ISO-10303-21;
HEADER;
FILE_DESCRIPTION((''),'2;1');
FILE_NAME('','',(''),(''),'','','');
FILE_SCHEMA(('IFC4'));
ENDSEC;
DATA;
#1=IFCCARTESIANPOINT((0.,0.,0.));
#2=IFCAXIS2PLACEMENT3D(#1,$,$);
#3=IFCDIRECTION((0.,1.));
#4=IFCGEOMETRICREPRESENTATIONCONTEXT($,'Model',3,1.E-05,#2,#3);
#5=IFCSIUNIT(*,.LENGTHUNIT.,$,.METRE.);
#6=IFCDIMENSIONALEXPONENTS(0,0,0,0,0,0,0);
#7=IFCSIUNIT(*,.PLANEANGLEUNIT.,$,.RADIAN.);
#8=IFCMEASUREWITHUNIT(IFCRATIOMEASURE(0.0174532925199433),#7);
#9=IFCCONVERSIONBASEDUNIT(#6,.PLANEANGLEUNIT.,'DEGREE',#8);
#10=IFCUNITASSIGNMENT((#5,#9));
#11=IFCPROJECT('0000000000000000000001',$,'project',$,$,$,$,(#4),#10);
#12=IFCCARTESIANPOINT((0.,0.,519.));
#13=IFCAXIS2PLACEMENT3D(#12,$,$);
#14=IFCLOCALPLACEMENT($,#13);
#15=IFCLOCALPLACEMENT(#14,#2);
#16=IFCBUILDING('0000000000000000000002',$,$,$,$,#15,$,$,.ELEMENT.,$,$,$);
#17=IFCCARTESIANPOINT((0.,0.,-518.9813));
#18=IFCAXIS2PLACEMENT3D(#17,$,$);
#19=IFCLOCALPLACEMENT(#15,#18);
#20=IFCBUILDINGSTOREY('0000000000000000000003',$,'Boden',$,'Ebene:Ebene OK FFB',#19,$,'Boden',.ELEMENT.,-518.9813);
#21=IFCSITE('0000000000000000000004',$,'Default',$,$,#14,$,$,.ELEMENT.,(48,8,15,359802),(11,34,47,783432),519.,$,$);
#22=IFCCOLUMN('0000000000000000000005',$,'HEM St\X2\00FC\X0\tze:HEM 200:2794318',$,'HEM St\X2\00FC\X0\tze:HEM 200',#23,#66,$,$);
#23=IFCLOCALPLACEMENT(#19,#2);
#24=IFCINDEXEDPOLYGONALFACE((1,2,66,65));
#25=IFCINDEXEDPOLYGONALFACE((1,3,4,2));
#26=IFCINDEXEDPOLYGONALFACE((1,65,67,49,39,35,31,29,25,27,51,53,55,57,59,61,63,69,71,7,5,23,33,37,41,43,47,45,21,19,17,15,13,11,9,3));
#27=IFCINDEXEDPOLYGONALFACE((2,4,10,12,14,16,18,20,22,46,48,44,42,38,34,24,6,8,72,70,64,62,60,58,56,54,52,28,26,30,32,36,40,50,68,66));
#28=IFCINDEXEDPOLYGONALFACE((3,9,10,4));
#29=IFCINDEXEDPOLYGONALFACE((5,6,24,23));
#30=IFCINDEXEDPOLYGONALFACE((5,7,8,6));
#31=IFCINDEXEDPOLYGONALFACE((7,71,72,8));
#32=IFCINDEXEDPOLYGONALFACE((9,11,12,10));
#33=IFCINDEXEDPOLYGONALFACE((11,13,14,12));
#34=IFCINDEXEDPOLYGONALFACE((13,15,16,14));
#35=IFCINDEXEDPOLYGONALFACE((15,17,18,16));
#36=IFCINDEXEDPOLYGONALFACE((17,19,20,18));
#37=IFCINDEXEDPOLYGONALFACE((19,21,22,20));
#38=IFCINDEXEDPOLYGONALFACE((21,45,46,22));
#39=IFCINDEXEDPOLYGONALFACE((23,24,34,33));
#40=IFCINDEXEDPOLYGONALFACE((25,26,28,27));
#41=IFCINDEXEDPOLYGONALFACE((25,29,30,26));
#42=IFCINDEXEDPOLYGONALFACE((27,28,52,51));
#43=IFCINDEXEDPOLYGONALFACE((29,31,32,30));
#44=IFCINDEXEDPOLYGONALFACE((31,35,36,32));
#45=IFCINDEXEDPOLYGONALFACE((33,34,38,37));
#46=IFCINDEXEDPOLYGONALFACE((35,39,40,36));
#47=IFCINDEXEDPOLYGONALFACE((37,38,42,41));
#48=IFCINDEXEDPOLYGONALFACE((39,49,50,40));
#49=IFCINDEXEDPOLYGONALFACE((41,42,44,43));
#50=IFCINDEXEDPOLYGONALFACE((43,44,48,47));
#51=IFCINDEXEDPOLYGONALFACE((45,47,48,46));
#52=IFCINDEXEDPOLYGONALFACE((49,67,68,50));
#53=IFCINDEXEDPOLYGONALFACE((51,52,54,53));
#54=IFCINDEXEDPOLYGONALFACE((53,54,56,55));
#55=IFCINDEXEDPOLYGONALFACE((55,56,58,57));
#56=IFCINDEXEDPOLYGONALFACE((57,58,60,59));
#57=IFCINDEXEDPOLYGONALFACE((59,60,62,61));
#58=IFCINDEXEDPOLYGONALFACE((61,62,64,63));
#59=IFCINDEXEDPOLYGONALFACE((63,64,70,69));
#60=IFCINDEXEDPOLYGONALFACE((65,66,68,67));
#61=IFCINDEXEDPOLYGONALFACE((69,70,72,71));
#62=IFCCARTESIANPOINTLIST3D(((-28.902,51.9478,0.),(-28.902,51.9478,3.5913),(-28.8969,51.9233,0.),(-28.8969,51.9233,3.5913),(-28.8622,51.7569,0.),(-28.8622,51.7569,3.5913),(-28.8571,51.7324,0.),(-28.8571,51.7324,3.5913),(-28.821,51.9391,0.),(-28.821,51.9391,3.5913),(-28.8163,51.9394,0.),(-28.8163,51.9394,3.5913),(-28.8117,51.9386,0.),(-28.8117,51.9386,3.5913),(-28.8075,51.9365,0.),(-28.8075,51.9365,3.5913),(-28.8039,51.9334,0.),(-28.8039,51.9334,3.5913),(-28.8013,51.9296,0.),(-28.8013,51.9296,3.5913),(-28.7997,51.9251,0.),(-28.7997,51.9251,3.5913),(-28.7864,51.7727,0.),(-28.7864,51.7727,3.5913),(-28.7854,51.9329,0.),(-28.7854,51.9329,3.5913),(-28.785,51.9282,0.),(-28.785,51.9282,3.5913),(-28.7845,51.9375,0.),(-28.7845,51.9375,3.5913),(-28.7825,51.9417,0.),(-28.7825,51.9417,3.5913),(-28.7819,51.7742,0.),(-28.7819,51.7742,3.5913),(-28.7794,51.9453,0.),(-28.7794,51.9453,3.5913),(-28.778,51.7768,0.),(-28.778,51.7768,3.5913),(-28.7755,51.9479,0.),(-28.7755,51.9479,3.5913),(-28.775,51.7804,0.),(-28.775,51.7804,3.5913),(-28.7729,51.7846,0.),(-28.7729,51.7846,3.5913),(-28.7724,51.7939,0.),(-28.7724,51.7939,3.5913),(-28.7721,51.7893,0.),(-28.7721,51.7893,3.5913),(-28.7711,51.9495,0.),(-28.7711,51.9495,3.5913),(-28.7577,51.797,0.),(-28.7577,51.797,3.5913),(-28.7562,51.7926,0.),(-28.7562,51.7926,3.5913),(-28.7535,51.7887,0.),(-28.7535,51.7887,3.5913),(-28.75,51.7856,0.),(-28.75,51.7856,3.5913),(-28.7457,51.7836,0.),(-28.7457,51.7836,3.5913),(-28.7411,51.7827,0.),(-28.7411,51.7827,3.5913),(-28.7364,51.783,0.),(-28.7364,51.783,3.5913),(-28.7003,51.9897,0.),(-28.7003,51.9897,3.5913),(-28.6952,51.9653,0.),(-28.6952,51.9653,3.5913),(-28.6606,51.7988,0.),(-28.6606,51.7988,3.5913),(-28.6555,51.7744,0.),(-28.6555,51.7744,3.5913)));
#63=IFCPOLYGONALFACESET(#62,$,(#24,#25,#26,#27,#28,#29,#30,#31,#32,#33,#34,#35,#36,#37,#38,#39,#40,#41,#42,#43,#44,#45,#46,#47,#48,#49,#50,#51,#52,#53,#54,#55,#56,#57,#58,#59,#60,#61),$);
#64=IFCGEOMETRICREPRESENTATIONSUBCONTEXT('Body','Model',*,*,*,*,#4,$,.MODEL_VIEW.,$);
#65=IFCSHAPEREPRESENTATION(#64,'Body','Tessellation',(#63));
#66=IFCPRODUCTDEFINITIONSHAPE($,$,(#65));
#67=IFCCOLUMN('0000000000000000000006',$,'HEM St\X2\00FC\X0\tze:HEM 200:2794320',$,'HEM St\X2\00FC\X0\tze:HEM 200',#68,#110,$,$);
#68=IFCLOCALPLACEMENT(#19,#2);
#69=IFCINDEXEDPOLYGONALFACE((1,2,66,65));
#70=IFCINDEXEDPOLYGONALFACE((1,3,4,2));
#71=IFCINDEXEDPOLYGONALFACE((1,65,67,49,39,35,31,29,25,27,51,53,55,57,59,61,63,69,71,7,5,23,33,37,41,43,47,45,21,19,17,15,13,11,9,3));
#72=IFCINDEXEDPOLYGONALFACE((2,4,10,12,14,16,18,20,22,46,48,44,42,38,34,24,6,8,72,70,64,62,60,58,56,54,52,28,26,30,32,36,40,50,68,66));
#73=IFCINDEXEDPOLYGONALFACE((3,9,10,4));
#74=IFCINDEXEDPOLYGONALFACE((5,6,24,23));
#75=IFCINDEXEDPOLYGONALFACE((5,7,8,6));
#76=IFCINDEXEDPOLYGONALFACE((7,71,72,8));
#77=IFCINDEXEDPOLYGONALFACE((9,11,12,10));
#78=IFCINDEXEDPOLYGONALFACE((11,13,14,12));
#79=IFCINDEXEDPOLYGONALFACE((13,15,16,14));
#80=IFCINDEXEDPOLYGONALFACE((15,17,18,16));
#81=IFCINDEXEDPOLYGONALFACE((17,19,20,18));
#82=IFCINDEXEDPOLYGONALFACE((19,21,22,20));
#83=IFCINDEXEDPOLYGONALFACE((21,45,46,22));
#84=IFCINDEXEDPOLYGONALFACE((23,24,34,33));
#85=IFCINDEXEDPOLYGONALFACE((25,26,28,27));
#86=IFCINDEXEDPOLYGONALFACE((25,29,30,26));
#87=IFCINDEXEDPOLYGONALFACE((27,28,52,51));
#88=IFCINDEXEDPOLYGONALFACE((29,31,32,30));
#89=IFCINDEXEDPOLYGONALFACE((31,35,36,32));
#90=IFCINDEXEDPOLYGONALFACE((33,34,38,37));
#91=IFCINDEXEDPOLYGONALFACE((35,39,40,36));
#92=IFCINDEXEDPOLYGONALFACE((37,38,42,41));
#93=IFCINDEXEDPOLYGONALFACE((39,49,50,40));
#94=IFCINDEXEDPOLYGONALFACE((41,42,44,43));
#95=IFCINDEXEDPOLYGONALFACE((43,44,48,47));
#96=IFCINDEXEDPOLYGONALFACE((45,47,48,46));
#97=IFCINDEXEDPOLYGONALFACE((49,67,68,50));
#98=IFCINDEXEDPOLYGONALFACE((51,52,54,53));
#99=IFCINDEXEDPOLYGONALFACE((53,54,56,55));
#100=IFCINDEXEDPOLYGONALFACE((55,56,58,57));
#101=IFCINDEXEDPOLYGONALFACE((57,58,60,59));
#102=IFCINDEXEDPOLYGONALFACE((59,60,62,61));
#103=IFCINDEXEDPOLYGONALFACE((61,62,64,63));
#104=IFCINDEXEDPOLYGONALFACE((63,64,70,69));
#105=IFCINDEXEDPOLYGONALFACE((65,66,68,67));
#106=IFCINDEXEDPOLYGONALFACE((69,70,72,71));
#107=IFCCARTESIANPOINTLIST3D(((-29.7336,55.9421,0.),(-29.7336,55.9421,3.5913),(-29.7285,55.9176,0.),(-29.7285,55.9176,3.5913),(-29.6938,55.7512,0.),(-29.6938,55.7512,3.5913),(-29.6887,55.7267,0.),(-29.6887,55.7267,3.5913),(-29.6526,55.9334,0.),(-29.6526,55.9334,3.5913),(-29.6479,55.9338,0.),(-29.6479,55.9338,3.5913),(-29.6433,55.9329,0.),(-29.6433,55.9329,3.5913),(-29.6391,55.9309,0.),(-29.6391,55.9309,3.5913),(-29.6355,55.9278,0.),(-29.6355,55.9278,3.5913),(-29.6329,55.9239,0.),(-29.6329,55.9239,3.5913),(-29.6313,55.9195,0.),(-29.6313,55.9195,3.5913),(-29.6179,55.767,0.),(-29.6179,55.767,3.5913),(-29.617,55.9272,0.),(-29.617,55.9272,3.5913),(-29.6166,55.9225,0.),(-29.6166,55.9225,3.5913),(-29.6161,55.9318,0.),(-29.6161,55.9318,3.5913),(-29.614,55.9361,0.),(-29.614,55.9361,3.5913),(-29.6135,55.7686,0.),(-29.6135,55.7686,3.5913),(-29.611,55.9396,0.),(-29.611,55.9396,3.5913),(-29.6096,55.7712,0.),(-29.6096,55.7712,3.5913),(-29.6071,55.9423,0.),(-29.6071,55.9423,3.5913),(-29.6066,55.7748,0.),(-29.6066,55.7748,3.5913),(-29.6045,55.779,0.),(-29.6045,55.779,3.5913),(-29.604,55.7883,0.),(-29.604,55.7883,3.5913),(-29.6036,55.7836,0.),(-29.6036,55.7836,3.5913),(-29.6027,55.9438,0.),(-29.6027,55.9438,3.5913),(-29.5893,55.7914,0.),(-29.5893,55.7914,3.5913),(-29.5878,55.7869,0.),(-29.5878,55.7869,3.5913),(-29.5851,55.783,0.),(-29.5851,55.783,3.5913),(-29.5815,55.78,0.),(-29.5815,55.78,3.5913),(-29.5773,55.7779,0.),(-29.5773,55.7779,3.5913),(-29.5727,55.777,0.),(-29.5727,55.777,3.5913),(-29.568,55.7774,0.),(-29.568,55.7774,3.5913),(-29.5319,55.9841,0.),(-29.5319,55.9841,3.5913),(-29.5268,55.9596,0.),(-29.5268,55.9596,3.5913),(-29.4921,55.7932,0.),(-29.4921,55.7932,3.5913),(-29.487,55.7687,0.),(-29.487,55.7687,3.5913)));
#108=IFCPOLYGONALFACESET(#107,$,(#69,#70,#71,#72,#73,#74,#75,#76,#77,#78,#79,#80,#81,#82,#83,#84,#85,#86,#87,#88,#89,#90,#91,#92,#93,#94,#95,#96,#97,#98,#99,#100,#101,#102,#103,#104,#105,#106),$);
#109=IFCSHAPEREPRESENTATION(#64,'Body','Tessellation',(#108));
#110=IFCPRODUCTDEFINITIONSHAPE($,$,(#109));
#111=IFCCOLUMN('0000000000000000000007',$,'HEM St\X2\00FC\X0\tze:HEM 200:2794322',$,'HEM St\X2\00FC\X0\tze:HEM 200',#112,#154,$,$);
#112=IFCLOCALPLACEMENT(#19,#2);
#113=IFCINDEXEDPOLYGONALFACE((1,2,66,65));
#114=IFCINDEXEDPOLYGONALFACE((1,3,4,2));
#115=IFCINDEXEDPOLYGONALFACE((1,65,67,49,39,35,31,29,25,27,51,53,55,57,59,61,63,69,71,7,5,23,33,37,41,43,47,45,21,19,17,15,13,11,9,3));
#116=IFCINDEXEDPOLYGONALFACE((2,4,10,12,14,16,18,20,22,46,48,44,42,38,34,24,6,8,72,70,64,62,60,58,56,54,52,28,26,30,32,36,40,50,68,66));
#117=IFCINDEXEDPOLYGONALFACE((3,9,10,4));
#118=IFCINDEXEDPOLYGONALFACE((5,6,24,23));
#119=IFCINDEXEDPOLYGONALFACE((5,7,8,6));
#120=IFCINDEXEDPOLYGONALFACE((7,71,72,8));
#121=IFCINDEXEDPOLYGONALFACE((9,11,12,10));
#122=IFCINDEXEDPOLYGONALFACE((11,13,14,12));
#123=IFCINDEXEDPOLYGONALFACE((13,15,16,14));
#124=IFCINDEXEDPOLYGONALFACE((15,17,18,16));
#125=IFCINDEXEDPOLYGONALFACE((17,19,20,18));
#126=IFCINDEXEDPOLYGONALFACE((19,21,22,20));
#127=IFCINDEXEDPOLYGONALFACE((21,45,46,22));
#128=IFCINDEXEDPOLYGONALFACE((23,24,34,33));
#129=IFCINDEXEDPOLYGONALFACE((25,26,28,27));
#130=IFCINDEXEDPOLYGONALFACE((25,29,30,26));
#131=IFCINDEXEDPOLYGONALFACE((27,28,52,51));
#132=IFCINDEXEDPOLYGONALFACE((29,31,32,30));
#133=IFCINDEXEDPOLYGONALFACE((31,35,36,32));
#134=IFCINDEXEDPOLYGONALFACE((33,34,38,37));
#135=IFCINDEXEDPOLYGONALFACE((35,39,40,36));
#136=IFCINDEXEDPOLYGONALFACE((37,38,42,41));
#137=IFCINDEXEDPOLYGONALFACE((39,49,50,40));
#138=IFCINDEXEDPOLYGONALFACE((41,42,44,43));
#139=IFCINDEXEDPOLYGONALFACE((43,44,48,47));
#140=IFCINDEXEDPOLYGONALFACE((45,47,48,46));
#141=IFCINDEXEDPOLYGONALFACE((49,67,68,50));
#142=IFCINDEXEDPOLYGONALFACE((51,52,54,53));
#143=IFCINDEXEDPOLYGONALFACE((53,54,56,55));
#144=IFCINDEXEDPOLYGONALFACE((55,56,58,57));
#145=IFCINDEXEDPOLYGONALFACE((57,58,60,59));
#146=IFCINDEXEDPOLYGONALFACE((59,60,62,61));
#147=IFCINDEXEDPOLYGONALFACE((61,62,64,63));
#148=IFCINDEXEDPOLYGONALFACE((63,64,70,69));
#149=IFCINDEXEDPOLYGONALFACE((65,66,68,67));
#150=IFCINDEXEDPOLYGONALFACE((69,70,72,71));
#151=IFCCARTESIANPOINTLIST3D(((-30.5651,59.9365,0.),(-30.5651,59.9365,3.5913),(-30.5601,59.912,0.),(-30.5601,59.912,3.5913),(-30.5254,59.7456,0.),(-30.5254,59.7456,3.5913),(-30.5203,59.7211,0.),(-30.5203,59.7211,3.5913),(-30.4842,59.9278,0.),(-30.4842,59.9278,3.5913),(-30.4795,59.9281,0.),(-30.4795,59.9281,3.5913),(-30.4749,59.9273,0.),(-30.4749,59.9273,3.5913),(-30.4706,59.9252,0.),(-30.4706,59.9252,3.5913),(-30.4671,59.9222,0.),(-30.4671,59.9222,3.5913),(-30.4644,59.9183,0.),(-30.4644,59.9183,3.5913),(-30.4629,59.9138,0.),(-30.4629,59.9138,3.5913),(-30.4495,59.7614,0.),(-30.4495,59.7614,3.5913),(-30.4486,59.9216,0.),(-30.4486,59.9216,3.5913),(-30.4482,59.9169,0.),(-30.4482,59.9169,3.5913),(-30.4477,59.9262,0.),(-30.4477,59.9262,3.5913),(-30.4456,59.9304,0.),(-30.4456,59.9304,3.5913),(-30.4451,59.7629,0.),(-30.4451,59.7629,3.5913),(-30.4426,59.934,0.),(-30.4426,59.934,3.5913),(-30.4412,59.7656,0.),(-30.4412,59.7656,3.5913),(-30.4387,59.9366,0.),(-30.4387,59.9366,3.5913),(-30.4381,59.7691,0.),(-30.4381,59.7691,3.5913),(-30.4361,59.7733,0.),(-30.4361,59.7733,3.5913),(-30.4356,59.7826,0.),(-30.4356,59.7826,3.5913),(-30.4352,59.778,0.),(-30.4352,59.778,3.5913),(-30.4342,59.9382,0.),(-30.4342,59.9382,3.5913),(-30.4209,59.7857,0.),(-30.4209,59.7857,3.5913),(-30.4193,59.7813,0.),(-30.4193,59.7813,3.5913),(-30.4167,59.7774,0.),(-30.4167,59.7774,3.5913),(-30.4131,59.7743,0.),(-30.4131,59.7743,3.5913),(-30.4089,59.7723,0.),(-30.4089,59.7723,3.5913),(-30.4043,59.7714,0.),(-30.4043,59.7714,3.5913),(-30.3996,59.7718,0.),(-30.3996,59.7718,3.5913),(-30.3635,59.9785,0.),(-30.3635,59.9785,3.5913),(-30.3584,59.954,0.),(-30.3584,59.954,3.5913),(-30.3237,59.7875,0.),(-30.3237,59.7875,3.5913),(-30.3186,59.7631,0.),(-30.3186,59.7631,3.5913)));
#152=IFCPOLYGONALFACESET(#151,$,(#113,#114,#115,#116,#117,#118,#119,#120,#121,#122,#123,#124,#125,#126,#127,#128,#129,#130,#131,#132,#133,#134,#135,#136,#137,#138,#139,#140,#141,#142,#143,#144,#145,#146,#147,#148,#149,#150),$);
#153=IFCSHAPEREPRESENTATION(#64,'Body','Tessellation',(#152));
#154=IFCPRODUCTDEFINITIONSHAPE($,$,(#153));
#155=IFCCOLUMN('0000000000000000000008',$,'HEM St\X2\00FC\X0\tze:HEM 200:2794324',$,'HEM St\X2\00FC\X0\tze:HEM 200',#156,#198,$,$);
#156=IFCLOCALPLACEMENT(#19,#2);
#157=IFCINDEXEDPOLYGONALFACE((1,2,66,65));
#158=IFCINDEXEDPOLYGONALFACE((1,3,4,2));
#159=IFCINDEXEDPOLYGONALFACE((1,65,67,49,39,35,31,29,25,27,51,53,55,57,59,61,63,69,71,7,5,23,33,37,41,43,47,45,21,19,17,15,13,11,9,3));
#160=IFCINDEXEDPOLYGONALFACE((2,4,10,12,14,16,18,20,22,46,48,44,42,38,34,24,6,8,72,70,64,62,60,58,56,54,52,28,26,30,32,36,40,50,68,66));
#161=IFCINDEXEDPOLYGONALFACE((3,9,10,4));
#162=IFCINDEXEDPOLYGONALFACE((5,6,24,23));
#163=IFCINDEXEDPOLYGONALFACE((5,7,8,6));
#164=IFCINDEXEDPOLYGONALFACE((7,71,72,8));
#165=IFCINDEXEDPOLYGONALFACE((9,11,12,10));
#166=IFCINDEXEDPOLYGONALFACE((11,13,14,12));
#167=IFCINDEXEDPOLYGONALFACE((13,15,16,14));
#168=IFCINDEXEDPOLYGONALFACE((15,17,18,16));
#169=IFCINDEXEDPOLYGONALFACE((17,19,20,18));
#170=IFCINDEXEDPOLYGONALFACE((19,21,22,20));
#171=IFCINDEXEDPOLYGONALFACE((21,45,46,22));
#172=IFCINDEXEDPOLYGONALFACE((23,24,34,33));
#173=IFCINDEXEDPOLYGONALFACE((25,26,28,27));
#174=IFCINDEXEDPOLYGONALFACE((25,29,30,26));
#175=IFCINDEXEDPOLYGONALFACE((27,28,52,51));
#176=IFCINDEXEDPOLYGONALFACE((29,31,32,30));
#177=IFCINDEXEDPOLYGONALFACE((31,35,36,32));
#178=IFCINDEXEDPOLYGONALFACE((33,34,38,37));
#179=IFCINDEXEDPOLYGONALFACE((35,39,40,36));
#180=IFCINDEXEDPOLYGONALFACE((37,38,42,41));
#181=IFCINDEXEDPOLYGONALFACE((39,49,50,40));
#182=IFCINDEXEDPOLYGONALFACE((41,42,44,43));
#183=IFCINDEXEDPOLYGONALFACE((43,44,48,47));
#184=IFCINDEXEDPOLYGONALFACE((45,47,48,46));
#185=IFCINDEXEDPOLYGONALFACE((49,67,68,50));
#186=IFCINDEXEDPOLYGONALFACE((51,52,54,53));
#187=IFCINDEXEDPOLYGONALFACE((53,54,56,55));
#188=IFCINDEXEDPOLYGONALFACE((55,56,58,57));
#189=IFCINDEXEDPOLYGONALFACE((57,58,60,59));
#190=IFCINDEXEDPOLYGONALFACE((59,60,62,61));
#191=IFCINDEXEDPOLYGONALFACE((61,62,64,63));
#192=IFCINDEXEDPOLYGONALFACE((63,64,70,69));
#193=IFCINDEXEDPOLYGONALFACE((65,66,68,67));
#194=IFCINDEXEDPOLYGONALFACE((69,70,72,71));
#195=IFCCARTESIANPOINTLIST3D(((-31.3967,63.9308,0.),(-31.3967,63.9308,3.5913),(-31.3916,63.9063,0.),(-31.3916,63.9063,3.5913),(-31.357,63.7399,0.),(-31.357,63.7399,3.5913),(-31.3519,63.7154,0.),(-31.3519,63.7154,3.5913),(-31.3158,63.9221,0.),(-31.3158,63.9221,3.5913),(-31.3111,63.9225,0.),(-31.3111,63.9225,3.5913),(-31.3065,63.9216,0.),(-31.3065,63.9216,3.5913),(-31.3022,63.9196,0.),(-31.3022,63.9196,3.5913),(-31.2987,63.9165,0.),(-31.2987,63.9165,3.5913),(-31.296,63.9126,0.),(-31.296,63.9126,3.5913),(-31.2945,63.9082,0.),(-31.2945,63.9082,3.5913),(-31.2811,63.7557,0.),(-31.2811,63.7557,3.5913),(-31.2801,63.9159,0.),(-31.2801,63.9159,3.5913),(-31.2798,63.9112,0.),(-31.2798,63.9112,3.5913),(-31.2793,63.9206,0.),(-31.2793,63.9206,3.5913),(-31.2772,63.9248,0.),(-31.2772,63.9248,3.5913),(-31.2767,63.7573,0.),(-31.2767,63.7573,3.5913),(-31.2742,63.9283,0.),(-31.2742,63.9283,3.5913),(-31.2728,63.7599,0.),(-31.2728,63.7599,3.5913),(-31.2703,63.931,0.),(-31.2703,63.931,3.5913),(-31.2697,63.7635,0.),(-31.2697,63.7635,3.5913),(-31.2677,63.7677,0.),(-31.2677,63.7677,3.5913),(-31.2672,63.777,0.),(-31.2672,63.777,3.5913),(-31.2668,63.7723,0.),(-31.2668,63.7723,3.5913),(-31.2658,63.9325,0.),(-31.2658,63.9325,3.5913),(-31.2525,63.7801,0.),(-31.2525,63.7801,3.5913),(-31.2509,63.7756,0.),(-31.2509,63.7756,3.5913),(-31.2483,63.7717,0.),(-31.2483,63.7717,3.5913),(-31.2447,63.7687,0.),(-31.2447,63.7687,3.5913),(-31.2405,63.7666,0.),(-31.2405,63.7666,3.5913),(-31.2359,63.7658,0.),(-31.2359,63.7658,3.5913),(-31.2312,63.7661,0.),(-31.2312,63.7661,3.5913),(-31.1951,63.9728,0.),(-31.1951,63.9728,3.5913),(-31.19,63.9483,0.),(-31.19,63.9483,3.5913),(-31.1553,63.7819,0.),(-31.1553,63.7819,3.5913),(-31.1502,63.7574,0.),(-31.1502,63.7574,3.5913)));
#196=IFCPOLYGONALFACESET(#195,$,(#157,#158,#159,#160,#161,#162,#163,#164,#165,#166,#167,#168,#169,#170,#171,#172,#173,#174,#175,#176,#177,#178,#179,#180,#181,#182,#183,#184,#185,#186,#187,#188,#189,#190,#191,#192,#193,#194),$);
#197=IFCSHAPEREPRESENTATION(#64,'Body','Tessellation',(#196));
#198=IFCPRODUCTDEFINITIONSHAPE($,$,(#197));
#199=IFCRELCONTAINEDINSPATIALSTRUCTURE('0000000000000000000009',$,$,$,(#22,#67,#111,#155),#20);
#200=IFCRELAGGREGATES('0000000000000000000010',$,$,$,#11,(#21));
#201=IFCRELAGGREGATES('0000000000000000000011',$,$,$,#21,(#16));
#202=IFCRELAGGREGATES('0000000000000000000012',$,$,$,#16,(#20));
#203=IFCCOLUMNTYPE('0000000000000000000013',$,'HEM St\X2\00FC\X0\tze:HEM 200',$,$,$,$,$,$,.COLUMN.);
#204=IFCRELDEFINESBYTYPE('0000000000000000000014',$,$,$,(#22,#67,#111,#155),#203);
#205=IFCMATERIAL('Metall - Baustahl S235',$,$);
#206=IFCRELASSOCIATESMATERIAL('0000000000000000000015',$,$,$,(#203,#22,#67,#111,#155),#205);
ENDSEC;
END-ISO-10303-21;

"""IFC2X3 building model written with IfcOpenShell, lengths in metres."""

from ifc_helpers import new_model, entity, si_unit, converted_unit, direction, frame, frame_2d, origin, place, context, subcontext, project, spatial, polyline, circle_curve, parameter, trimmed, segment, composite_curve, outline, extrude, source, transform, mapped, material, type_object, type_shapes, element, save


model = new_model("IFC2X3")

# Units and contexts
model_context = context("Model", 3, precision=1e-05, world=origin(), true_north=direction((0.0, 1.0)))
body_context = subcontext(model_context, "Body", "Model", "MODEL_VIEW")
ifc_project = project(units=[si_unit("LENGTHUNIT", "METRE"), converted_unit("PLANEANGLEUNIT", "DEGREE", entity("IfcRatioMeasure", 0.0174532925199433), si_unit("PLANEANGLEUNIT", "RADIAN"), dimensions=[0, 0, 0, 0, 0, 0, 0])], contexts=[model_context])

# Site, building, storey
site_placement = place(None, frame((0.0, 0.0, 519.0)))
site = spatial("IfcSite", under=ifc_project, at=site_placement, Name="Default", CompositionType="ELEMENT", RefLatitude=(48, 8, 15, 359802), RefLongitude=(11, 34, 47, 783432), RefElevation=519.0)
building_placement = place(site_placement, origin())
building = spatial("IfcBuilding", under=site, at=building_placement, CompositionType="ELEMENT")
storey_placement = place(building_placement, frame((0.0, 0.0, -518.9813)))
storey = spatial("IfcBuildingStorey", under=building, at=storey_placement, Name="Boden", ObjectType="Ebene:Ebene OK FFB", LongName="Boden", CompositionType="ELEMENT", Elevation=-518.9813)

# Columns
ifc_material = material(Name="Metall - Baustahl S235")
column_type = type_object("IfcColumnType", Name="HEM Stütze:HEM 200", PredefinedType="COLUMN", material=ifc_material)
shared_shape = source(origin(), body_context, "Body", "SweptSolid", [
    extrude(outline(composite_curve([segment(polyline([(0.085, -0.103), (0.11, -0.103)]), True, "CONTINUOUS"), segment(polyline([(0.11, -0.103), (0.11, 0.103)]), True, "CONTINUOUS"), segment(polyline([(0.11, 0.103), (0.085, 0.103)]), True, "CONTINUOUS"), segment(polyline([(0.085, 0.103), (0.085, 0.0255)]), True, "CONTINUOUS"), segment(trimmed(circle_curve(frame_2d((0.067, 0.0255), x_axis=(1.0, 0.0)), 0.018), [parameter(270.0)], [parameter(0.0)], True, "PARAMETER"), False, "CONTINUOUS"), segment(polyline([(0.067, 0.0075), (-0.067, 0.0075)]), True, "CONTINUOUS"), segment(trimmed(circle_curve(frame_2d((-0.067, 0.0255), x_axis=(0.0, -1.0)), 0.018), [parameter(270.0)], [parameter(0.0)], True, "PARAMETER"), False, "CONTINUOUS"), segment(polyline([(-0.085, 0.0255), (-0.085, 0.103)]), True, "CONTINUOUS"), segment(polyline([(-0.085, 0.103), (-0.11, 0.103)]), True, "CONTINUOUS"), segment(polyline([(-0.11, 0.103), (-0.11, -0.103)]), True, "CONTINUOUS"), segment(polyline([(-0.11, -0.103), (-0.085, -0.103)]), True, "CONTINUOUS"), segment(polyline([(-0.085, -0.103), (-0.085, -0.0255)]), True, "CONTINUOUS"), segment(trimmed(circle_curve(frame_2d((-0.067, -0.0255), x_axis=(-1.0, 0.0)), 0.018), [parameter(270.0)], [parameter(0.0)], True, "PARAMETER"), False, "CONTINUOUS"), segment(polyline([(-0.067, -0.0075), (0.067, -0.0075)]), True, "CONTINUOUS"), segment(trimmed(circle_curve(frame_2d((0.067, -0.0255), x_axis=(0.0, 1.0)), 0.018), [parameter(270.0)], [parameter(0.0)], True, "PARAMETER"), False, "CONTINUOUS"), segment(polyline([(0.085, -0.0255), (0.085, -0.103)]), True, "CONTINUOUS")], self_intersect=False)), frame((0.0, 0.0, -518.9813), z_axis=(0.0, 0.0, 1.0), x_axis=(0.0, -1.0, 0.0)), (0.0, 0.0, 1.0), 3.5913),
])
type_shapes(column_type, [shared_shape])
for number, where, z_axis, x_axis, name in (
    (1, (-28.7787, 51.8611, 518.9813), (0.0, 0.0, 1.0), (0.979008, 0.20382, 0.0), "HEM Stütze:HEM 200:2794318"),
    (2, (-29.6103, 55.8554, 518.9813), (0.0, 0.0, 1.0), (0.979008, 0.20382, 0.0), "HEM Stütze:HEM 200:2794320"),
    (3, (-30.4419, 59.8498, 518.9813), (0.0, 0.0, 1.0), (0.979008, 0.20382, 0.0), "HEM Stütze:HEM 200:2794322"),
    (4, (-31.2735, 63.8441, 518.9813), (0.0, 0.0, 1.0), (0.979008, 0.20382, 0.0), "HEM Stütze:HEM 200:2794324"),
):
    element("IfcColumn", number, at=place(storey_placement, frame(where, z_axis=z_axis, x_axis=x_axis)), inside=storey, type_object=column_type, material=ifc_material, Name=name, ObjectType="HEM Stütze:HEM 200", context=body_context, shape_type="MappedRepresentation", body=[
        mapped(shared_shape, transform((0.0, 0.0, 0.0), scale=1.0)),
    ])

save(model, "model.ifc")
